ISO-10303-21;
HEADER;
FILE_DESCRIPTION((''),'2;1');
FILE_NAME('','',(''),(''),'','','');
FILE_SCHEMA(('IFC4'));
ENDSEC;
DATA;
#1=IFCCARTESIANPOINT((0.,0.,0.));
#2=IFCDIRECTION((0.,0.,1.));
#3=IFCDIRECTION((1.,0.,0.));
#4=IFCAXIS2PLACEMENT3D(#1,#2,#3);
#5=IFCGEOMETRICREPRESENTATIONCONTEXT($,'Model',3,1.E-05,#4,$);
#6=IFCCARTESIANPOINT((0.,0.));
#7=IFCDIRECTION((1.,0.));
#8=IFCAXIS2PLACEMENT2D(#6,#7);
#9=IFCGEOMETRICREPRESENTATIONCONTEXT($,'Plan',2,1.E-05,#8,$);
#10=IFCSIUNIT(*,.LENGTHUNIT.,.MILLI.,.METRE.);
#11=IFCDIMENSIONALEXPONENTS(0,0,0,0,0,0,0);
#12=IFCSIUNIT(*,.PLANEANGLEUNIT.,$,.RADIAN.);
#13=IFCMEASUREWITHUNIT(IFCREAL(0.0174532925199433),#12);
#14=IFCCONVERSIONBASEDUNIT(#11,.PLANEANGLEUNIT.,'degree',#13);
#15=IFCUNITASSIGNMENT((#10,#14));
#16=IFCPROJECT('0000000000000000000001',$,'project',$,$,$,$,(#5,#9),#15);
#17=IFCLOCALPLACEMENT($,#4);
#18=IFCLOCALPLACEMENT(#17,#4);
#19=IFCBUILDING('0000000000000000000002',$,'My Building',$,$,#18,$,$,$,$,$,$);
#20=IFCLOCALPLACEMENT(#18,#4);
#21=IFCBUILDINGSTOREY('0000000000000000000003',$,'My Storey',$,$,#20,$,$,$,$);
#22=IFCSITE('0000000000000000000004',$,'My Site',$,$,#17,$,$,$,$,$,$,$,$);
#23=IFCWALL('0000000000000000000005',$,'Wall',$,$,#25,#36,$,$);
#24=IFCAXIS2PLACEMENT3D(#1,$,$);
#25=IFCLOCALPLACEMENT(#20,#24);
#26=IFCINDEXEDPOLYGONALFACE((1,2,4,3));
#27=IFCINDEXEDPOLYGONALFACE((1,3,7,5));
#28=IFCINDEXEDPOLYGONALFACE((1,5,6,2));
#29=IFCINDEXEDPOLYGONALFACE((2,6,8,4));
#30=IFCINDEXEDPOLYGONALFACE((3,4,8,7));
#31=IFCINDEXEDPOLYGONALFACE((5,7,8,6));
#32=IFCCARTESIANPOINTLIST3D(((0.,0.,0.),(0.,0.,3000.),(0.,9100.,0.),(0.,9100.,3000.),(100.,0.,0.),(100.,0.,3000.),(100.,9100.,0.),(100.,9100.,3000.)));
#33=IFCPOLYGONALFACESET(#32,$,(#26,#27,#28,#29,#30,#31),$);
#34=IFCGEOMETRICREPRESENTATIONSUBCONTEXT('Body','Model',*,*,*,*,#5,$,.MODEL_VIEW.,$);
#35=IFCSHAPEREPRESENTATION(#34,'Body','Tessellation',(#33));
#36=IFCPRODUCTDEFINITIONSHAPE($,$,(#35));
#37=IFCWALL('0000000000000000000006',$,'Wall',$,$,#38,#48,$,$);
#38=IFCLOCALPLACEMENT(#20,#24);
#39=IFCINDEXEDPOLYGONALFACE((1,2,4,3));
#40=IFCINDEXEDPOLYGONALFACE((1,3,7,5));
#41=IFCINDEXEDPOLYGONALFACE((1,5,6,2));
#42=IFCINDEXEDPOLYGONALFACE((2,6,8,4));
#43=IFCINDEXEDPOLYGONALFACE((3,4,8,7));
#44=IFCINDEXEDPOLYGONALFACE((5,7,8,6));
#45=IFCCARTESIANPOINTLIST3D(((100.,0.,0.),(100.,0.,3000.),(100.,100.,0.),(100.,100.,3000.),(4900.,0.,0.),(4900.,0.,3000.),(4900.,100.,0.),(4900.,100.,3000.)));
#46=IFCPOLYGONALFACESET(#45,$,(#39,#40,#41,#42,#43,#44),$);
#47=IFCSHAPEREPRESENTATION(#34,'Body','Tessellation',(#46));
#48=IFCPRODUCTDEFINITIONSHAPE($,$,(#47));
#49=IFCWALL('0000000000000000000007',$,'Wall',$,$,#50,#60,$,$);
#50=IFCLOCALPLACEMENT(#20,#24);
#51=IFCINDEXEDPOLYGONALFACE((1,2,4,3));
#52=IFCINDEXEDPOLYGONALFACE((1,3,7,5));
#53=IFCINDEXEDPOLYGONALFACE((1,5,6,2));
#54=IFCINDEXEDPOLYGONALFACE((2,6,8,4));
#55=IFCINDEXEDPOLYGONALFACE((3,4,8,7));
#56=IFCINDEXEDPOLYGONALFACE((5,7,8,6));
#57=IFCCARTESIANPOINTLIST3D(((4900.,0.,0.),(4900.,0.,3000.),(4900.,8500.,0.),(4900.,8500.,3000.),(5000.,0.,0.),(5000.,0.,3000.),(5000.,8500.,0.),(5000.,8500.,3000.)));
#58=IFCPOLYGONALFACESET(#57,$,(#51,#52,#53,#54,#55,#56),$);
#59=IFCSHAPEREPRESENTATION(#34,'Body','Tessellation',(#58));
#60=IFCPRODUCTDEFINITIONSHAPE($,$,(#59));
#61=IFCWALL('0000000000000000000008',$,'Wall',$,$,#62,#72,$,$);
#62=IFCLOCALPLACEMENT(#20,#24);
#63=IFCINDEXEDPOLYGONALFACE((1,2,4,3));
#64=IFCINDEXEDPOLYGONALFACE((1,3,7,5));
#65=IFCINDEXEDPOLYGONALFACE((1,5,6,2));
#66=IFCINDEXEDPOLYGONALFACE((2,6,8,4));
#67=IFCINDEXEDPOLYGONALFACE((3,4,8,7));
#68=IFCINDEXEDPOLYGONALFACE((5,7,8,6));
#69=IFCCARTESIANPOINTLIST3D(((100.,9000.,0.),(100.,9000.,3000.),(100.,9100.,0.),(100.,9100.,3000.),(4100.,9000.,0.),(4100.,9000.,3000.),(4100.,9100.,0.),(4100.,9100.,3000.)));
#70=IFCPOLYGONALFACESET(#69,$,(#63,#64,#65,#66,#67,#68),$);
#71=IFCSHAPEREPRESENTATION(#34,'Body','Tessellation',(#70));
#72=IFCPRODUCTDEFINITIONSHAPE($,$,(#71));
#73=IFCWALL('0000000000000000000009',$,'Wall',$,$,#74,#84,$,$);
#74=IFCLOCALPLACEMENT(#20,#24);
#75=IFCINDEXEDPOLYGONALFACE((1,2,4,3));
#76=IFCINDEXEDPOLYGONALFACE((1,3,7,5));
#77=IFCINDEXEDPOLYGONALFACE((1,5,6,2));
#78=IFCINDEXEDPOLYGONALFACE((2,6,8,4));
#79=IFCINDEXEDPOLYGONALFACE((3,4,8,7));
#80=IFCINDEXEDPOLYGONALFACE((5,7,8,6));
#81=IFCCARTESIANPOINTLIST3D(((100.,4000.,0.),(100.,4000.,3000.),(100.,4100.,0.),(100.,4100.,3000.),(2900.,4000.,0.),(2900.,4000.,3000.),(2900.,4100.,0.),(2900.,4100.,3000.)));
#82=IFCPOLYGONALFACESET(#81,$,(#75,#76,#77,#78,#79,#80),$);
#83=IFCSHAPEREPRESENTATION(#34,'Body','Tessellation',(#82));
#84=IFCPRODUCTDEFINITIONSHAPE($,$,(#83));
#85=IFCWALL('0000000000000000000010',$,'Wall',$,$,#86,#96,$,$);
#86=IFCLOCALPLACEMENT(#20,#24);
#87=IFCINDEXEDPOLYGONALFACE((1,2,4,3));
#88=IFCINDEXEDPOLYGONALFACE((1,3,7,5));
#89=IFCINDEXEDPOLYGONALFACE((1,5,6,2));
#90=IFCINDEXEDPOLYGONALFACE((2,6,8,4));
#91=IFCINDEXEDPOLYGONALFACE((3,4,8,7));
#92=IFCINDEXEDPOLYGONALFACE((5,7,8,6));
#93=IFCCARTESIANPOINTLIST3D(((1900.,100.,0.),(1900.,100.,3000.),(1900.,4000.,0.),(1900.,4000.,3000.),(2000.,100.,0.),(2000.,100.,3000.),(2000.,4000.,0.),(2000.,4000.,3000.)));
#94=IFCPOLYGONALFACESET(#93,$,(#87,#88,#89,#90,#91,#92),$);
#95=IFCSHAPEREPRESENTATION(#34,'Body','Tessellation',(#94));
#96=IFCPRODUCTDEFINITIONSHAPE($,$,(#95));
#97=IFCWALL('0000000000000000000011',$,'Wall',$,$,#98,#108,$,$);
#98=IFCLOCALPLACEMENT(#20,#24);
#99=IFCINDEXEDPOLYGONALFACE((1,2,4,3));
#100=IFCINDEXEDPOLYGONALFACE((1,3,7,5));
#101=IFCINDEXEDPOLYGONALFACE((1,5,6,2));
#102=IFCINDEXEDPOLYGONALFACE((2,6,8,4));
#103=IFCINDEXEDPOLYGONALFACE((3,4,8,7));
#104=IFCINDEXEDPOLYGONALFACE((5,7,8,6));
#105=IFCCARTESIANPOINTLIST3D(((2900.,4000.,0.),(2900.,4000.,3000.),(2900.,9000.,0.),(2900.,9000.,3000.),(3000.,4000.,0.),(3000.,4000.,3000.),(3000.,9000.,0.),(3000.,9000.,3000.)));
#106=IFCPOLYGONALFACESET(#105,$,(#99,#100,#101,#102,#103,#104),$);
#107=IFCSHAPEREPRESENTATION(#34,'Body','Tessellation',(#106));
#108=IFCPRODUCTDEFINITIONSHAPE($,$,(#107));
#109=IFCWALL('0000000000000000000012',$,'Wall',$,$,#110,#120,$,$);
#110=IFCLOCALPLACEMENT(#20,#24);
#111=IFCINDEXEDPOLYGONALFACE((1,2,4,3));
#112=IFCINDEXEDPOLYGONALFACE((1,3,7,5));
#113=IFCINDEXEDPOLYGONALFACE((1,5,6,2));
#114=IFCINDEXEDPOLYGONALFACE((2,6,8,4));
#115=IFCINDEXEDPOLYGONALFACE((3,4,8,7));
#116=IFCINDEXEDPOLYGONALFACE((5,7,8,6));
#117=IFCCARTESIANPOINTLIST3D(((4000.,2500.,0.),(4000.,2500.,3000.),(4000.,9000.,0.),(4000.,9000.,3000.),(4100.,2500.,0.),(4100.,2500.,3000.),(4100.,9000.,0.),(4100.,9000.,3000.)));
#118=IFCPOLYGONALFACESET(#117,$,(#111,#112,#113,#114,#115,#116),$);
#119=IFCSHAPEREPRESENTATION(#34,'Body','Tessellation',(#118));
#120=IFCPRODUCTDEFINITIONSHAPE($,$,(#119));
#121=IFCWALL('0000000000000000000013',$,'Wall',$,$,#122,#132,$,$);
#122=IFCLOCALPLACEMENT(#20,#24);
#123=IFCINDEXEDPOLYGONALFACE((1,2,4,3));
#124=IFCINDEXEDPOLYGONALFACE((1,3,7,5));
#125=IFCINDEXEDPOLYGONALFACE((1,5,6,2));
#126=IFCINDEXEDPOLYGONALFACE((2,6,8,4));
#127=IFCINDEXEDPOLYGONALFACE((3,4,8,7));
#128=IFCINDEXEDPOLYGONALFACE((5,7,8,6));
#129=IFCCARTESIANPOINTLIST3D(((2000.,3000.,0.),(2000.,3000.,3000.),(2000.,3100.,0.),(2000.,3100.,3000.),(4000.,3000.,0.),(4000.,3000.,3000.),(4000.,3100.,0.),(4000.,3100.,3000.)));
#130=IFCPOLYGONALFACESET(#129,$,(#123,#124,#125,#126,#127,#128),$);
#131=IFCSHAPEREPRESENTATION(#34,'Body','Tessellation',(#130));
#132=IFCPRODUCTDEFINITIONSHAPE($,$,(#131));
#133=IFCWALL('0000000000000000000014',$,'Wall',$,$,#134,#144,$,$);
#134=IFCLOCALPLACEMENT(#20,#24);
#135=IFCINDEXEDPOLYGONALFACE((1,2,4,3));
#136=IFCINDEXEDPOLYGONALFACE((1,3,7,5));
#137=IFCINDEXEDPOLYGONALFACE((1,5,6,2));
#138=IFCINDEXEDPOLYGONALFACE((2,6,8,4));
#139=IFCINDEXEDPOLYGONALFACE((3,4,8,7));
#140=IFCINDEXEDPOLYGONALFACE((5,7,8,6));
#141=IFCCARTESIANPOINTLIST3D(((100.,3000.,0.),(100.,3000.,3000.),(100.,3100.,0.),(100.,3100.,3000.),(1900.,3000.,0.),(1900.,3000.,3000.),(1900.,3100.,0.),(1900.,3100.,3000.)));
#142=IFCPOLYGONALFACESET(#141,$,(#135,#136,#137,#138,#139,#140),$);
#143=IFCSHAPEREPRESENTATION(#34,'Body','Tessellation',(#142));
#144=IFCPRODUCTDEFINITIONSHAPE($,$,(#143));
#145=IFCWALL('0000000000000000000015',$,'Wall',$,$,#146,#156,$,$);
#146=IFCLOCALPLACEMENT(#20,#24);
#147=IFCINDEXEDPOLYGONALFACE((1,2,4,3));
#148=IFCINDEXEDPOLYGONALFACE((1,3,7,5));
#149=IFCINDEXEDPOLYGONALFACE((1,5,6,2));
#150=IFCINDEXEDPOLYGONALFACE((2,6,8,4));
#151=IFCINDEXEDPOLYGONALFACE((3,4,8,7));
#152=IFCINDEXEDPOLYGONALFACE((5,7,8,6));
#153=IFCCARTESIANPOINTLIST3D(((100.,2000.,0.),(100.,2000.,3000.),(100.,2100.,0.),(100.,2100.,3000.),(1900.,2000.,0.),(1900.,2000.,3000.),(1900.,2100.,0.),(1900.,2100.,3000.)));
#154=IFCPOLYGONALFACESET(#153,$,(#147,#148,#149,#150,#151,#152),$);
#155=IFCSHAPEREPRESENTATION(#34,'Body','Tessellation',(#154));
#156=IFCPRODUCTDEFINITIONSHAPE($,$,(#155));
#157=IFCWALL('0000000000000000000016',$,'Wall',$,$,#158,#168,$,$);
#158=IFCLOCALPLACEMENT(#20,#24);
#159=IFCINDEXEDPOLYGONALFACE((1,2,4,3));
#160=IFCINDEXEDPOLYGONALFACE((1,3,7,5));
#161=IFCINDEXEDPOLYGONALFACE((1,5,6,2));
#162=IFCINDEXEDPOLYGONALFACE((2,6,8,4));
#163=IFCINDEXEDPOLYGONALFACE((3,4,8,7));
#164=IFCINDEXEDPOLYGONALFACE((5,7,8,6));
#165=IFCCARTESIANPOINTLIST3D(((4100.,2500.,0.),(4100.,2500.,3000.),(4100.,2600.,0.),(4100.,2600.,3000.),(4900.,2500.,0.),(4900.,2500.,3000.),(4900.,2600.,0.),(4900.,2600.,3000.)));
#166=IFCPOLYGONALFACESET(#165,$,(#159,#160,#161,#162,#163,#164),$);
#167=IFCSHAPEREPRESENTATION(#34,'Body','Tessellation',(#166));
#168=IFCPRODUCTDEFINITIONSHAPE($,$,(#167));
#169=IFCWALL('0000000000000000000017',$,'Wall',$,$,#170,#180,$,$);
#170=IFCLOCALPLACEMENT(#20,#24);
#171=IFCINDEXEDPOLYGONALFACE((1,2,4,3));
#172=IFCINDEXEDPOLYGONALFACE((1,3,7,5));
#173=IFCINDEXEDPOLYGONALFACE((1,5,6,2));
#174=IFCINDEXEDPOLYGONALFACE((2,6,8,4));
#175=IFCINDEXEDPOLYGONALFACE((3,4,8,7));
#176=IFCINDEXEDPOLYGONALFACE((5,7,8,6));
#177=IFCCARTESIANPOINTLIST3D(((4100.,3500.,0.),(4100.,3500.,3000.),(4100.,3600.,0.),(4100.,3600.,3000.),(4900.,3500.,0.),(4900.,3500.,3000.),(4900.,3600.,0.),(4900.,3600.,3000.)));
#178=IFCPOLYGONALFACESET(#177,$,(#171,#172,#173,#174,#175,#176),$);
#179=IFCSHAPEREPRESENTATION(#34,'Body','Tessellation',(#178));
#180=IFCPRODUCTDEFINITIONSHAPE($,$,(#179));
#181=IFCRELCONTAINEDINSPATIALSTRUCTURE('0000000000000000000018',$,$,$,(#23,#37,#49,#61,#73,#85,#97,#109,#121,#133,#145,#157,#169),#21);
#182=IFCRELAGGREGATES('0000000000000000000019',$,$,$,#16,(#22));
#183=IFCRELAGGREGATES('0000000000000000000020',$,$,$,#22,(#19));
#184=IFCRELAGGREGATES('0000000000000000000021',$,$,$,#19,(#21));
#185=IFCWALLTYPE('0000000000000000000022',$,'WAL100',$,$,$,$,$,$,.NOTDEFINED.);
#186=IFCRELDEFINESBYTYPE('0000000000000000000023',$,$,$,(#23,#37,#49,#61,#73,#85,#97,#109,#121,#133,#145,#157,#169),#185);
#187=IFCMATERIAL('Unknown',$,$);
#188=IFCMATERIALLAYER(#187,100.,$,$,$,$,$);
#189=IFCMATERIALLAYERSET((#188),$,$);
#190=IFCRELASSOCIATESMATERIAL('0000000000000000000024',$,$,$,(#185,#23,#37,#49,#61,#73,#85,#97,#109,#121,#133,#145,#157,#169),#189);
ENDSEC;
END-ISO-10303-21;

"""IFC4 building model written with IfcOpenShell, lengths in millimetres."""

from ifc_helpers import new_model, entity, si_unit, converted_unit, frame, origin_with_axes, origin_2d_with_axis, place, context, subcontext, project, spatial, indexed_curve, outline, extrude, material, layer, layer_set, layer_usage, type_object, element, save


model = new_model("IFC4")

# Units and contexts
model_context = context("Model", 3, precision=1e-05, world=origin_with_axes())
plan_context = context("Plan", 2, precision=1e-05, world=origin_2d_with_axis())
body_context = subcontext(model_context, "Body", "Model", "MODEL_VIEW")
ifc_project = project(units=[si_unit("LENGTHUNIT", "METRE", prefix="MILLI"), converted_unit("PLANEANGLEUNIT", "degree", entity("IfcReal", 0.0174532925199433), si_unit("PLANEANGLEUNIT", "RADIAN"), dimensions=[0, 0, 0, 0, 0, 0, 0])], contexts=[model_context, plan_context])

# Site, building, storey
site_placement = place(None, origin_with_axes())
site = spatial("IfcSite", under=ifc_project, at=site_placement, Name="My Site")
building_placement = place(site_placement, origin_with_axes())
building = spatial("IfcBuilding", under=site, at=building_placement, Name="My Building")
storey_placement = place(building_placement, origin_with_axes())
storey = spatial("IfcBuildingStorey", under=building, at=storey_placement, Name="My Storey")

# Walls
ifc_material = material(Name="Unknown")
ifc_layer = layer(ifc_material, 100.0)
ifc_layer_set = layer_set([ifc_layer])
ifc_layer_usage_1 = layer_usage(ifc_layer_set, "AXIS2", "POSITIVE", 0.0)
wall_type = type_object("IfcWallType", Name="WAL100", PredefinedType="NOTDEFINED", material=ifc_layer_set)
wall_1_placement = place(storey_placement, frame((0.0, 9100.0, 0.0), z_axis=(0.0, 0.0, 1.0), x_axis=(0.0, -1.0, 0.0)))
element("IfcWall", 1, at=wall_1_placement, inside=storey, type_object=wall_type, material=ifc_layer_usage_1, Name="Wall", context=body_context, shape_type="SweptSolid", body=[
    extrude(outline(indexed_curve([(0.0, 0.0), (0.0, 100.0), (9100.0, 100.0), (9100.0, 0.0), (0.0, 0.0)], self_intersect=False)), origin_with_axes(), (0.0, 0.0, 1.0), 3000.0),
])
ifc_layer_usage_2 = layer_usage(ifc_layer_set, "AXIS2", "POSITIVE", 0.0)
wall_2_placement = place(storey_placement, frame((100.0, 0.0, 0.0), z_axis=(0.0, 0.0, 1.0), x_axis=(1.0, 0.0, 0.0)))
element("IfcWall", 2, at=wall_2_placement, inside=storey, type_object=wall_type, material=ifc_layer_usage_2, Name="Wall", context=body_context, shape_type="SweptSolid", body=[
    extrude(outline(indexed_curve([(0.0, 0.0), (0.0, 100.0), (4800.0, 100.0), (4800.0, 0.0), (0.0, 0.0)], self_intersect=False)), origin_with_axes(), (0.0, 0.0, 1.0), 3000.0),
])
ifc_layer_usage_3 = layer_usage(ifc_layer_set, "AXIS2", "POSITIVE", 0.0)
wall_3_placement = place(storey_placement, frame((5000.0, 0.0, 0.0), z_axis=(0.0, 0.0, 1.0), x_axis=(0.0, 1.0, 0.0)))
element("IfcWall", 3, at=wall_3_placement, inside=storey, type_object=wall_type, material=ifc_layer_usage_3, Name="Wall", context=body_context, shape_type="SweptSolid", body=[
    extrude(outline(indexed_curve([(0.0, 0.0), (0.0, 100.0), (8500.0, 100.0), (8500.0, 0.0), (0.0, 0.0)], self_intersect=False)), origin_with_axes(), (0.0, 0.0, 1.0), 3000.0),
])
ifc_layer_usage_4 = layer_usage(ifc_layer_set, "AXIS2", "POSITIVE", 0.0)
wall_4_placement = place(storey_placement, frame((100.0, 9000.0, 0.0), z_axis=(0.0, 0.0, 1.0), x_axis=(1.0, 0.0, 0.0)))
element("IfcWall", 4, at=wall_4_placement, inside=storey, type_object=wall_type, material=ifc_layer_usage_4, Name="Wall", context=body_context, shape_type="SweptSolid", body=[
    extrude(outline(indexed_curve([(0.0, 0.0), (0.0, 100.0), (4000.0, 100.0), (4000.0, 0.0), (0.0, 0.0)], self_intersect=False)), origin_with_axes(), (0.0, 0.0, 1.0), 3000.0),
])
ifc_layer_usage_5 = layer_usage(ifc_layer_set, "AXIS2", "POSITIVE", 0.0)
wall_5_placement = place(storey_placement, frame((100.0, 4000.0, 0.0), z_axis=(0.0, 0.0, 1.0), x_axis=(1.0, 0.0, 0.0)))
element("IfcWall", 5, at=wall_5_placement, inside=storey, type_object=wall_type, material=ifc_layer_usage_5, Name="Wall", context=body_context, shape_type="SweptSolid", body=[
    extrude(outline(indexed_curve([(0.0, 0.0), (0.0, 100.0), (2800.0, 100.0), (2800.0, 0.0), (0.0, 0.0)], self_intersect=False)), origin_with_axes(), (0.0, 0.0, 1.0), 3000.0),
])
ifc_layer_usage_6 = layer_usage(ifc_layer_set, "AXIS2", "POSITIVE", 0.0)
wall_6_placement = place(storey_placement, frame((2000.0, 100.0, 0.0), z_axis=(0.0, 0.0, 1.0), x_axis=(0.0, 1.0, 0.0)))
element("IfcWall", 6, at=wall_6_placement, inside=storey, type_object=wall_type, material=ifc_layer_usage_6, Name="Wall", context=body_context, shape_type="SweptSolid", body=[
    extrude(outline(indexed_curve([(0.0, 0.0), (0.0, 100.0), (3900.0, 100.0), (3900.0, 0.0), (0.0, 0.0)], self_intersect=False)), origin_with_axes(), (0.0, 0.0, 1.0), 3000.0),
])
ifc_layer_usage_7 = layer_usage(ifc_layer_set, "AXIS2", "POSITIVE", 0.0)
wall_7_placement = place(storey_placement, frame((3000.0, 4000.0, 0.0), z_axis=(0.0, 0.0, 1.0), x_axis=(0.0, 1.0, 0.0)))
element("IfcWall", 7, at=wall_7_placement, inside=storey, type_object=wall_type, material=ifc_layer_usage_7, Name="Wall", context=body_context, shape_type="SweptSolid", body=[
    extrude(outline(indexed_curve([(0.0, 0.0), (0.0, 100.0), (5000.0, 100.0), (5000.0, 0.0), (0.0, 0.0)], self_intersect=False)), origin_with_axes(), (0.0, 0.0, 1.0), 3000.0),
])
ifc_layer_usage_8 = layer_usage(ifc_layer_set, "AXIS2", "POSITIVE", 0.0)
wall_8_placement = place(storey_placement, frame((4000.0, 9000.0, 0.0), z_axis=(0.0, 0.0, 1.0), x_axis=(0.0, -1.0, 0.0)))
element("IfcWall", 8, at=wall_8_placement, inside=storey, type_object=wall_type, material=ifc_layer_usage_8, Name="Wall", context=body_context, shape_type="SweptSolid", body=[
    extrude(outline(indexed_curve([(0.0, 0.0), (0.0, 100.0), (6500.0, 100.0), (6500.0, 0.0), (0.0, 0.0)], self_intersect=False)), origin_with_axes(), (0.0, 0.0, 1.0), 3000.0),
])
ifc_layer_usage_9 = layer_usage(ifc_layer_set, "AXIS2", "POSITIVE", 0.0)
wall_9_placement = place(storey_placement, frame((2000.0, 3000.0, 0.0), z_axis=(0.0, 0.0, 1.0), x_axis=(1.0, 0.0, 0.0)))
element("IfcWall", 9, at=wall_9_placement, inside=storey, type_object=wall_type, material=ifc_layer_usage_9, Name="Wall", context=body_context, shape_type="SweptSolid", body=[
    extrude(outline(indexed_curve([(0.0, 0.0), (0.0, 100.0), (2000.0, 100.0), (2000.0, 0.0), (0.0, 0.0)], self_intersect=False)), origin_with_axes(), (0.0, 0.0, 1.0), 3000.0),
])
ifc_layer_usage_10 = layer_usage(ifc_layer_set, "AXIS2", "POSITIVE", 0.0)
wall_10_placement = place(storey_placement, frame((100.0, 3000.0, 0.0), z_axis=(0.0, 0.0, 1.0), x_axis=(1.0, 0.0, 0.0)))
element("IfcWall", 10, at=wall_10_placement, inside=storey, type_object=wall_type, material=ifc_layer_usage_10, Name="Wall", context=body_context, shape_type="SweptSolid", body=[
    extrude(outline(indexed_curve([(0.0, 0.0), (0.0, 100.0), (1800.0, 100.0), (1800.0, 0.0), (0.0, 0.0)], self_intersect=False)), origin_with_axes(), (0.0, 0.0, 1.0), 3000.0),
])
ifc_layer_usage_11 = layer_usage(ifc_layer_set, "AXIS2", "POSITIVE", 0.0)
wall_11_placement = place(storey_placement, frame((100.0, 2000.0, 0.0), z_axis=(0.0, 0.0, 1.0), x_axis=(1.0, 0.0, 0.0)))
element("IfcWall", 11, at=wall_11_placement, inside=storey, type_object=wall_type, material=ifc_layer_usage_11, Name="Wall", context=body_context, shape_type="SweptSolid", body=[
    extrude(outline(indexed_curve([(0.0, 0.0), (0.0, 100.0), (1800.0, 100.0), (1800.0, 0.0), (0.0, 0.0)], self_intersect=False)), origin_with_axes(), (0.0, 0.0, 1.0), 3000.0),
])
ifc_layer_usage_12 = layer_usage(ifc_layer_set, "AXIS2", "POSITIVE", 0.0)
wall_12_placement = place(storey_placement, frame((4100.0, 2500.0, 0.0), z_axis=(0.0, 0.0, 1.0), x_axis=(1.0, 0.0, 0.0)))
element("IfcWall", 12, at=wall_12_placement, inside=storey, type_object=wall_type, material=ifc_layer_usage_12, Name="Wall", context=body_context, shape_type="SweptSolid", body=[
    extrude(outline(indexed_curve([(0.0, 0.0), (0.0, 100.0), (800.0, 100.0), (800.0, 0.0), (0.0, 0.0)], self_intersect=False)), origin_with_axes(), (0.0, 0.0, 1.0), 3000.0),
])
ifc_layer_usage_13 = layer_usage(ifc_layer_set, "AXIS2", "POSITIVE", 0.0)
wall_13_placement = place(storey_placement, frame((4100.0, 3500.0, 0.0), z_axis=(0.0, 0.0, 1.0), x_axis=(1.0, 0.0, 0.0)))
element("IfcWall", 13, at=wall_13_placement, inside=storey, type_object=wall_type, material=ifc_layer_usage_13, Name="Wall", context=body_context, shape_type="SweptSolid", body=[
    extrude(outline(indexed_curve([(0.0, 0.0), (0.0, 100.0), (800.0, 100.0), (800.0, 0.0), (0.0, 0.0)], self_intersect=False)), origin_with_axes(), (0.0, 0.0, 1.0), 3000.0),
])

save(model, "model.ifc")
